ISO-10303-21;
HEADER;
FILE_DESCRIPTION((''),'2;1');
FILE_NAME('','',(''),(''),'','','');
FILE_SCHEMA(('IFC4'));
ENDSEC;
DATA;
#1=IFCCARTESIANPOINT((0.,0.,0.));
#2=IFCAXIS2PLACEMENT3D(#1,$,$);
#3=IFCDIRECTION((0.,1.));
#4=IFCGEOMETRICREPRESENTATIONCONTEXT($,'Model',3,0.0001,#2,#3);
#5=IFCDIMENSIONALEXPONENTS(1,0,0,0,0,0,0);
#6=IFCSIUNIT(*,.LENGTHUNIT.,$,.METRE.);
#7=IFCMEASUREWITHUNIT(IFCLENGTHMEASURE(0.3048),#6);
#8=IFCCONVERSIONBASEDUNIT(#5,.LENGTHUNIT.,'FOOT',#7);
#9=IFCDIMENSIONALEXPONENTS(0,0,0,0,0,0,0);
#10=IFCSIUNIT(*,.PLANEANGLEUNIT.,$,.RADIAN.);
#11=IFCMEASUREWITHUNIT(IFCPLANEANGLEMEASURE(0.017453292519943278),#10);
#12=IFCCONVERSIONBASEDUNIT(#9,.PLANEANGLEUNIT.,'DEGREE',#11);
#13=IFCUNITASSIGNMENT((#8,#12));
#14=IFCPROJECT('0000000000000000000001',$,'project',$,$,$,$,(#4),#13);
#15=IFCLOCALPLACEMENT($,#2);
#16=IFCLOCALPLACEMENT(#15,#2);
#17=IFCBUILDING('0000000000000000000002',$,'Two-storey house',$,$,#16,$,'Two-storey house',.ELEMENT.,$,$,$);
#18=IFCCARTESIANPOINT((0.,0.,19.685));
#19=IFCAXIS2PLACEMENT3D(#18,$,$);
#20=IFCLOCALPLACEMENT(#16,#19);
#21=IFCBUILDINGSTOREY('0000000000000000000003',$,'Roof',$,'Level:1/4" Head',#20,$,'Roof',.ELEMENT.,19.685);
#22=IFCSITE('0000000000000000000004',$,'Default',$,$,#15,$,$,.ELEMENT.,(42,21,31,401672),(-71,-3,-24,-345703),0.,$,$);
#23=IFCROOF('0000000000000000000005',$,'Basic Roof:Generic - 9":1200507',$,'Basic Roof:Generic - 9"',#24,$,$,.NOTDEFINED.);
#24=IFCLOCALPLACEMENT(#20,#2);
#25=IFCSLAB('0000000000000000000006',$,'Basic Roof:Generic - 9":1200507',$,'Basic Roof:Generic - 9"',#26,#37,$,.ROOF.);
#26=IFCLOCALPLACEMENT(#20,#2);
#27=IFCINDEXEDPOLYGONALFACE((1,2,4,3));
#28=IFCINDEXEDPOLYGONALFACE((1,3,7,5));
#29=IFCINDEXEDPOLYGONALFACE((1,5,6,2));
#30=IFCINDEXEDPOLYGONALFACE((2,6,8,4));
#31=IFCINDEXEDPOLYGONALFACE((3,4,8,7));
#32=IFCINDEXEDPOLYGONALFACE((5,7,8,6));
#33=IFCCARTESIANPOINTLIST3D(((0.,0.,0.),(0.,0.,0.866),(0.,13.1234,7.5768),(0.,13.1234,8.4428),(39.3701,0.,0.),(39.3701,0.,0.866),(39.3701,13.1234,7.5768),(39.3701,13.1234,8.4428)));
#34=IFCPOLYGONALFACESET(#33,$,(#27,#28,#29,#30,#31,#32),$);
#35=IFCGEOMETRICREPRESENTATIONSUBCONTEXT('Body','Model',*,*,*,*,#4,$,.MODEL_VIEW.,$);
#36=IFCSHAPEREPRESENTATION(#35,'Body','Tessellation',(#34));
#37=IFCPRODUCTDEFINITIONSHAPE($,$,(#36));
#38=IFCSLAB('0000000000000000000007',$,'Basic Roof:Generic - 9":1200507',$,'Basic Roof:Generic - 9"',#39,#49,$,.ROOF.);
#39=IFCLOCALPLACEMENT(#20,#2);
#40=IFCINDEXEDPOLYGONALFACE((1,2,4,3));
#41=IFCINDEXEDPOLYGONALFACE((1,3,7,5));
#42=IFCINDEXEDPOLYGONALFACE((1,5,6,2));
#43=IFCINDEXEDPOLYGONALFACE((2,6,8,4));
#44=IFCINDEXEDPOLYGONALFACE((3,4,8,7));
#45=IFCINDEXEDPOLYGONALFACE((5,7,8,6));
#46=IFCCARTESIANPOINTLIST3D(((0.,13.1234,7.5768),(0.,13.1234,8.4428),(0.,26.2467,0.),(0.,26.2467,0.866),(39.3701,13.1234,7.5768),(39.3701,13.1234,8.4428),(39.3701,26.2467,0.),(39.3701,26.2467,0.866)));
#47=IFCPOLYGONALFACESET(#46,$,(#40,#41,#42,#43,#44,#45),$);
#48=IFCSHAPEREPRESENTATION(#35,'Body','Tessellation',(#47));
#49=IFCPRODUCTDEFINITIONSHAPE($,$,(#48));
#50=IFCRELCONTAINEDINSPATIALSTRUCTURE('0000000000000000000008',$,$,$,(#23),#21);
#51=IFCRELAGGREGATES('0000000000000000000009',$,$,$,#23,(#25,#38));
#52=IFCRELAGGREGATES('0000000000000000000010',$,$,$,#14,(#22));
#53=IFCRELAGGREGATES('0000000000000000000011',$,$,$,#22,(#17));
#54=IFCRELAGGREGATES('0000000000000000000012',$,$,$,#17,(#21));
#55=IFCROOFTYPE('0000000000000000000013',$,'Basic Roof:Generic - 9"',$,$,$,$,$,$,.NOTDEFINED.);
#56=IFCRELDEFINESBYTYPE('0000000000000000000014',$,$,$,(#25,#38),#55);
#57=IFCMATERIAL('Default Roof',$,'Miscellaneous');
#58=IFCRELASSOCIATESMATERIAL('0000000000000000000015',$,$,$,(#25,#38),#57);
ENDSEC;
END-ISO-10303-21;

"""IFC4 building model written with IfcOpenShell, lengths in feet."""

from ifc_helpers import new_model, entity, si_unit, converted_unit, direction, frame, origin, place, context, subcontext, project, spatial, indexed_curve, outline, extrude, material, type_object, element, aggregate, save


model = new_model("IFC4")

# Units and contexts
model_context = context("Model", 3, precision=0.0001, world=origin(), true_north=direction((0.0, 1.0)))
body_context = subcontext(model_context, "Body", "Model", "MODEL_VIEW")
ifc_project = project(units=[converted_unit("LENGTHUNIT", "FOOT", entity("IfcLengthMeasure", 0.3048), si_unit("LENGTHUNIT", "METRE"), dimensions=[1, 0, 0, 0, 0, 0, 0]), converted_unit("PLANEANGLEUNIT", "DEGREE", entity("IfcPlaneAngleMeasure", 0.017453292519943278), si_unit("PLANEANGLEUNIT", "RADIAN"), dimensions=[0, 0, 0, 0, 0, 0, 0])], contexts=[model_context])

# Site, building, storey
site_placement = place(None, origin())
site = spatial("IfcSite", under=ifc_project, at=site_placement, Name="Default", CompositionType="ELEMENT", RefLatitude=(42, 21, 31, 401672), RefLongitude=(-71, -3, -24, -345703), RefElevation=0.0)
building_placement = place(site_placement, origin())
building = spatial("IfcBuilding", under=site, at=building_placement, Name="Two-storey house", LongName="Two-storey house", CompositionType="ELEMENT")
storey_placement = place(building_placement, frame((0.0, 0.0, 19.685)))
storey = spatial("IfcBuildingStorey", under=building, at=storey_placement, Name="Roof", ObjectType="Level:1/4\" Head", LongName="Roof", CompositionType="ELEMENT", Elevation=19.685)

# Roof, slabs
roof_placement = place(storey_placement, origin())
roof = element("IfcRoof", 1, at=roof_placement, inside=storey, Name="Basic Roof:Generic - 9\":1200507", ObjectType="Basic Roof:Generic - 9\"", PredefinedType="NOTDEFINED")
ifc_material = material(Name="Default Roof", Category="Miscellaneous")
roof_type = type_object("IfcRoofType", Name="Basic Roof:Generic - 9\"", PredefinedType="NOTDEFINED")
slab_1_placement = place(roof_placement, origin())
slab_1 = element("IfcSlab", 2, at=slab_1_placement, type_object=roof_type, material=ifc_material, Name="Basic Roof:Generic - 9\":1200507", ObjectType="Basic Roof:Generic - 9\"", PredefinedType="ROOF", context=body_context, shape_type="SweptSolid", body=[
    extrude(outline(indexed_curve([(19.685, 7.5768), (-19.685, 7.5768), (-19.685, -7.5768), (19.685, -7.5768), (19.685, 7.5768)], self_intersect=False)), frame((19.685, 6.5617, 3.7884), z_axis=(0.0, -0.5, 0.866025), x_axis=(1.0, 0.0, 0.0)), (0.0, 0.5, 0.866025), 0.866),
])
slab_2_placement = place(roof_placement, origin())
slab_2 = element("IfcSlab", 3, at=slab_2_placement, type_object=roof_type, material=ifc_material, Name="Basic Roof:Generic - 9\":1200507", ObjectType="Basic Roof:Generic - 9\"", PredefinedType="ROOF", context=body_context, shape_type="SweptSolid", body=[
    extrude(outline(indexed_curve([(-19.685, 7.5768), (-19.685, -7.5768), (19.685, -7.5768), (19.685, 7.5768), (-19.685, 7.5768)], self_intersect=False)), frame((19.685, 19.685, 3.7884), z_axis=(0.0, 0.5, 0.866025), x_axis=(1.0, 0.0, 0.0)), (0.0, -0.5, 0.866025), 0.866),
])
aggregate(roof, [slab_1, slab_2])

save(model, "model.ifc")
